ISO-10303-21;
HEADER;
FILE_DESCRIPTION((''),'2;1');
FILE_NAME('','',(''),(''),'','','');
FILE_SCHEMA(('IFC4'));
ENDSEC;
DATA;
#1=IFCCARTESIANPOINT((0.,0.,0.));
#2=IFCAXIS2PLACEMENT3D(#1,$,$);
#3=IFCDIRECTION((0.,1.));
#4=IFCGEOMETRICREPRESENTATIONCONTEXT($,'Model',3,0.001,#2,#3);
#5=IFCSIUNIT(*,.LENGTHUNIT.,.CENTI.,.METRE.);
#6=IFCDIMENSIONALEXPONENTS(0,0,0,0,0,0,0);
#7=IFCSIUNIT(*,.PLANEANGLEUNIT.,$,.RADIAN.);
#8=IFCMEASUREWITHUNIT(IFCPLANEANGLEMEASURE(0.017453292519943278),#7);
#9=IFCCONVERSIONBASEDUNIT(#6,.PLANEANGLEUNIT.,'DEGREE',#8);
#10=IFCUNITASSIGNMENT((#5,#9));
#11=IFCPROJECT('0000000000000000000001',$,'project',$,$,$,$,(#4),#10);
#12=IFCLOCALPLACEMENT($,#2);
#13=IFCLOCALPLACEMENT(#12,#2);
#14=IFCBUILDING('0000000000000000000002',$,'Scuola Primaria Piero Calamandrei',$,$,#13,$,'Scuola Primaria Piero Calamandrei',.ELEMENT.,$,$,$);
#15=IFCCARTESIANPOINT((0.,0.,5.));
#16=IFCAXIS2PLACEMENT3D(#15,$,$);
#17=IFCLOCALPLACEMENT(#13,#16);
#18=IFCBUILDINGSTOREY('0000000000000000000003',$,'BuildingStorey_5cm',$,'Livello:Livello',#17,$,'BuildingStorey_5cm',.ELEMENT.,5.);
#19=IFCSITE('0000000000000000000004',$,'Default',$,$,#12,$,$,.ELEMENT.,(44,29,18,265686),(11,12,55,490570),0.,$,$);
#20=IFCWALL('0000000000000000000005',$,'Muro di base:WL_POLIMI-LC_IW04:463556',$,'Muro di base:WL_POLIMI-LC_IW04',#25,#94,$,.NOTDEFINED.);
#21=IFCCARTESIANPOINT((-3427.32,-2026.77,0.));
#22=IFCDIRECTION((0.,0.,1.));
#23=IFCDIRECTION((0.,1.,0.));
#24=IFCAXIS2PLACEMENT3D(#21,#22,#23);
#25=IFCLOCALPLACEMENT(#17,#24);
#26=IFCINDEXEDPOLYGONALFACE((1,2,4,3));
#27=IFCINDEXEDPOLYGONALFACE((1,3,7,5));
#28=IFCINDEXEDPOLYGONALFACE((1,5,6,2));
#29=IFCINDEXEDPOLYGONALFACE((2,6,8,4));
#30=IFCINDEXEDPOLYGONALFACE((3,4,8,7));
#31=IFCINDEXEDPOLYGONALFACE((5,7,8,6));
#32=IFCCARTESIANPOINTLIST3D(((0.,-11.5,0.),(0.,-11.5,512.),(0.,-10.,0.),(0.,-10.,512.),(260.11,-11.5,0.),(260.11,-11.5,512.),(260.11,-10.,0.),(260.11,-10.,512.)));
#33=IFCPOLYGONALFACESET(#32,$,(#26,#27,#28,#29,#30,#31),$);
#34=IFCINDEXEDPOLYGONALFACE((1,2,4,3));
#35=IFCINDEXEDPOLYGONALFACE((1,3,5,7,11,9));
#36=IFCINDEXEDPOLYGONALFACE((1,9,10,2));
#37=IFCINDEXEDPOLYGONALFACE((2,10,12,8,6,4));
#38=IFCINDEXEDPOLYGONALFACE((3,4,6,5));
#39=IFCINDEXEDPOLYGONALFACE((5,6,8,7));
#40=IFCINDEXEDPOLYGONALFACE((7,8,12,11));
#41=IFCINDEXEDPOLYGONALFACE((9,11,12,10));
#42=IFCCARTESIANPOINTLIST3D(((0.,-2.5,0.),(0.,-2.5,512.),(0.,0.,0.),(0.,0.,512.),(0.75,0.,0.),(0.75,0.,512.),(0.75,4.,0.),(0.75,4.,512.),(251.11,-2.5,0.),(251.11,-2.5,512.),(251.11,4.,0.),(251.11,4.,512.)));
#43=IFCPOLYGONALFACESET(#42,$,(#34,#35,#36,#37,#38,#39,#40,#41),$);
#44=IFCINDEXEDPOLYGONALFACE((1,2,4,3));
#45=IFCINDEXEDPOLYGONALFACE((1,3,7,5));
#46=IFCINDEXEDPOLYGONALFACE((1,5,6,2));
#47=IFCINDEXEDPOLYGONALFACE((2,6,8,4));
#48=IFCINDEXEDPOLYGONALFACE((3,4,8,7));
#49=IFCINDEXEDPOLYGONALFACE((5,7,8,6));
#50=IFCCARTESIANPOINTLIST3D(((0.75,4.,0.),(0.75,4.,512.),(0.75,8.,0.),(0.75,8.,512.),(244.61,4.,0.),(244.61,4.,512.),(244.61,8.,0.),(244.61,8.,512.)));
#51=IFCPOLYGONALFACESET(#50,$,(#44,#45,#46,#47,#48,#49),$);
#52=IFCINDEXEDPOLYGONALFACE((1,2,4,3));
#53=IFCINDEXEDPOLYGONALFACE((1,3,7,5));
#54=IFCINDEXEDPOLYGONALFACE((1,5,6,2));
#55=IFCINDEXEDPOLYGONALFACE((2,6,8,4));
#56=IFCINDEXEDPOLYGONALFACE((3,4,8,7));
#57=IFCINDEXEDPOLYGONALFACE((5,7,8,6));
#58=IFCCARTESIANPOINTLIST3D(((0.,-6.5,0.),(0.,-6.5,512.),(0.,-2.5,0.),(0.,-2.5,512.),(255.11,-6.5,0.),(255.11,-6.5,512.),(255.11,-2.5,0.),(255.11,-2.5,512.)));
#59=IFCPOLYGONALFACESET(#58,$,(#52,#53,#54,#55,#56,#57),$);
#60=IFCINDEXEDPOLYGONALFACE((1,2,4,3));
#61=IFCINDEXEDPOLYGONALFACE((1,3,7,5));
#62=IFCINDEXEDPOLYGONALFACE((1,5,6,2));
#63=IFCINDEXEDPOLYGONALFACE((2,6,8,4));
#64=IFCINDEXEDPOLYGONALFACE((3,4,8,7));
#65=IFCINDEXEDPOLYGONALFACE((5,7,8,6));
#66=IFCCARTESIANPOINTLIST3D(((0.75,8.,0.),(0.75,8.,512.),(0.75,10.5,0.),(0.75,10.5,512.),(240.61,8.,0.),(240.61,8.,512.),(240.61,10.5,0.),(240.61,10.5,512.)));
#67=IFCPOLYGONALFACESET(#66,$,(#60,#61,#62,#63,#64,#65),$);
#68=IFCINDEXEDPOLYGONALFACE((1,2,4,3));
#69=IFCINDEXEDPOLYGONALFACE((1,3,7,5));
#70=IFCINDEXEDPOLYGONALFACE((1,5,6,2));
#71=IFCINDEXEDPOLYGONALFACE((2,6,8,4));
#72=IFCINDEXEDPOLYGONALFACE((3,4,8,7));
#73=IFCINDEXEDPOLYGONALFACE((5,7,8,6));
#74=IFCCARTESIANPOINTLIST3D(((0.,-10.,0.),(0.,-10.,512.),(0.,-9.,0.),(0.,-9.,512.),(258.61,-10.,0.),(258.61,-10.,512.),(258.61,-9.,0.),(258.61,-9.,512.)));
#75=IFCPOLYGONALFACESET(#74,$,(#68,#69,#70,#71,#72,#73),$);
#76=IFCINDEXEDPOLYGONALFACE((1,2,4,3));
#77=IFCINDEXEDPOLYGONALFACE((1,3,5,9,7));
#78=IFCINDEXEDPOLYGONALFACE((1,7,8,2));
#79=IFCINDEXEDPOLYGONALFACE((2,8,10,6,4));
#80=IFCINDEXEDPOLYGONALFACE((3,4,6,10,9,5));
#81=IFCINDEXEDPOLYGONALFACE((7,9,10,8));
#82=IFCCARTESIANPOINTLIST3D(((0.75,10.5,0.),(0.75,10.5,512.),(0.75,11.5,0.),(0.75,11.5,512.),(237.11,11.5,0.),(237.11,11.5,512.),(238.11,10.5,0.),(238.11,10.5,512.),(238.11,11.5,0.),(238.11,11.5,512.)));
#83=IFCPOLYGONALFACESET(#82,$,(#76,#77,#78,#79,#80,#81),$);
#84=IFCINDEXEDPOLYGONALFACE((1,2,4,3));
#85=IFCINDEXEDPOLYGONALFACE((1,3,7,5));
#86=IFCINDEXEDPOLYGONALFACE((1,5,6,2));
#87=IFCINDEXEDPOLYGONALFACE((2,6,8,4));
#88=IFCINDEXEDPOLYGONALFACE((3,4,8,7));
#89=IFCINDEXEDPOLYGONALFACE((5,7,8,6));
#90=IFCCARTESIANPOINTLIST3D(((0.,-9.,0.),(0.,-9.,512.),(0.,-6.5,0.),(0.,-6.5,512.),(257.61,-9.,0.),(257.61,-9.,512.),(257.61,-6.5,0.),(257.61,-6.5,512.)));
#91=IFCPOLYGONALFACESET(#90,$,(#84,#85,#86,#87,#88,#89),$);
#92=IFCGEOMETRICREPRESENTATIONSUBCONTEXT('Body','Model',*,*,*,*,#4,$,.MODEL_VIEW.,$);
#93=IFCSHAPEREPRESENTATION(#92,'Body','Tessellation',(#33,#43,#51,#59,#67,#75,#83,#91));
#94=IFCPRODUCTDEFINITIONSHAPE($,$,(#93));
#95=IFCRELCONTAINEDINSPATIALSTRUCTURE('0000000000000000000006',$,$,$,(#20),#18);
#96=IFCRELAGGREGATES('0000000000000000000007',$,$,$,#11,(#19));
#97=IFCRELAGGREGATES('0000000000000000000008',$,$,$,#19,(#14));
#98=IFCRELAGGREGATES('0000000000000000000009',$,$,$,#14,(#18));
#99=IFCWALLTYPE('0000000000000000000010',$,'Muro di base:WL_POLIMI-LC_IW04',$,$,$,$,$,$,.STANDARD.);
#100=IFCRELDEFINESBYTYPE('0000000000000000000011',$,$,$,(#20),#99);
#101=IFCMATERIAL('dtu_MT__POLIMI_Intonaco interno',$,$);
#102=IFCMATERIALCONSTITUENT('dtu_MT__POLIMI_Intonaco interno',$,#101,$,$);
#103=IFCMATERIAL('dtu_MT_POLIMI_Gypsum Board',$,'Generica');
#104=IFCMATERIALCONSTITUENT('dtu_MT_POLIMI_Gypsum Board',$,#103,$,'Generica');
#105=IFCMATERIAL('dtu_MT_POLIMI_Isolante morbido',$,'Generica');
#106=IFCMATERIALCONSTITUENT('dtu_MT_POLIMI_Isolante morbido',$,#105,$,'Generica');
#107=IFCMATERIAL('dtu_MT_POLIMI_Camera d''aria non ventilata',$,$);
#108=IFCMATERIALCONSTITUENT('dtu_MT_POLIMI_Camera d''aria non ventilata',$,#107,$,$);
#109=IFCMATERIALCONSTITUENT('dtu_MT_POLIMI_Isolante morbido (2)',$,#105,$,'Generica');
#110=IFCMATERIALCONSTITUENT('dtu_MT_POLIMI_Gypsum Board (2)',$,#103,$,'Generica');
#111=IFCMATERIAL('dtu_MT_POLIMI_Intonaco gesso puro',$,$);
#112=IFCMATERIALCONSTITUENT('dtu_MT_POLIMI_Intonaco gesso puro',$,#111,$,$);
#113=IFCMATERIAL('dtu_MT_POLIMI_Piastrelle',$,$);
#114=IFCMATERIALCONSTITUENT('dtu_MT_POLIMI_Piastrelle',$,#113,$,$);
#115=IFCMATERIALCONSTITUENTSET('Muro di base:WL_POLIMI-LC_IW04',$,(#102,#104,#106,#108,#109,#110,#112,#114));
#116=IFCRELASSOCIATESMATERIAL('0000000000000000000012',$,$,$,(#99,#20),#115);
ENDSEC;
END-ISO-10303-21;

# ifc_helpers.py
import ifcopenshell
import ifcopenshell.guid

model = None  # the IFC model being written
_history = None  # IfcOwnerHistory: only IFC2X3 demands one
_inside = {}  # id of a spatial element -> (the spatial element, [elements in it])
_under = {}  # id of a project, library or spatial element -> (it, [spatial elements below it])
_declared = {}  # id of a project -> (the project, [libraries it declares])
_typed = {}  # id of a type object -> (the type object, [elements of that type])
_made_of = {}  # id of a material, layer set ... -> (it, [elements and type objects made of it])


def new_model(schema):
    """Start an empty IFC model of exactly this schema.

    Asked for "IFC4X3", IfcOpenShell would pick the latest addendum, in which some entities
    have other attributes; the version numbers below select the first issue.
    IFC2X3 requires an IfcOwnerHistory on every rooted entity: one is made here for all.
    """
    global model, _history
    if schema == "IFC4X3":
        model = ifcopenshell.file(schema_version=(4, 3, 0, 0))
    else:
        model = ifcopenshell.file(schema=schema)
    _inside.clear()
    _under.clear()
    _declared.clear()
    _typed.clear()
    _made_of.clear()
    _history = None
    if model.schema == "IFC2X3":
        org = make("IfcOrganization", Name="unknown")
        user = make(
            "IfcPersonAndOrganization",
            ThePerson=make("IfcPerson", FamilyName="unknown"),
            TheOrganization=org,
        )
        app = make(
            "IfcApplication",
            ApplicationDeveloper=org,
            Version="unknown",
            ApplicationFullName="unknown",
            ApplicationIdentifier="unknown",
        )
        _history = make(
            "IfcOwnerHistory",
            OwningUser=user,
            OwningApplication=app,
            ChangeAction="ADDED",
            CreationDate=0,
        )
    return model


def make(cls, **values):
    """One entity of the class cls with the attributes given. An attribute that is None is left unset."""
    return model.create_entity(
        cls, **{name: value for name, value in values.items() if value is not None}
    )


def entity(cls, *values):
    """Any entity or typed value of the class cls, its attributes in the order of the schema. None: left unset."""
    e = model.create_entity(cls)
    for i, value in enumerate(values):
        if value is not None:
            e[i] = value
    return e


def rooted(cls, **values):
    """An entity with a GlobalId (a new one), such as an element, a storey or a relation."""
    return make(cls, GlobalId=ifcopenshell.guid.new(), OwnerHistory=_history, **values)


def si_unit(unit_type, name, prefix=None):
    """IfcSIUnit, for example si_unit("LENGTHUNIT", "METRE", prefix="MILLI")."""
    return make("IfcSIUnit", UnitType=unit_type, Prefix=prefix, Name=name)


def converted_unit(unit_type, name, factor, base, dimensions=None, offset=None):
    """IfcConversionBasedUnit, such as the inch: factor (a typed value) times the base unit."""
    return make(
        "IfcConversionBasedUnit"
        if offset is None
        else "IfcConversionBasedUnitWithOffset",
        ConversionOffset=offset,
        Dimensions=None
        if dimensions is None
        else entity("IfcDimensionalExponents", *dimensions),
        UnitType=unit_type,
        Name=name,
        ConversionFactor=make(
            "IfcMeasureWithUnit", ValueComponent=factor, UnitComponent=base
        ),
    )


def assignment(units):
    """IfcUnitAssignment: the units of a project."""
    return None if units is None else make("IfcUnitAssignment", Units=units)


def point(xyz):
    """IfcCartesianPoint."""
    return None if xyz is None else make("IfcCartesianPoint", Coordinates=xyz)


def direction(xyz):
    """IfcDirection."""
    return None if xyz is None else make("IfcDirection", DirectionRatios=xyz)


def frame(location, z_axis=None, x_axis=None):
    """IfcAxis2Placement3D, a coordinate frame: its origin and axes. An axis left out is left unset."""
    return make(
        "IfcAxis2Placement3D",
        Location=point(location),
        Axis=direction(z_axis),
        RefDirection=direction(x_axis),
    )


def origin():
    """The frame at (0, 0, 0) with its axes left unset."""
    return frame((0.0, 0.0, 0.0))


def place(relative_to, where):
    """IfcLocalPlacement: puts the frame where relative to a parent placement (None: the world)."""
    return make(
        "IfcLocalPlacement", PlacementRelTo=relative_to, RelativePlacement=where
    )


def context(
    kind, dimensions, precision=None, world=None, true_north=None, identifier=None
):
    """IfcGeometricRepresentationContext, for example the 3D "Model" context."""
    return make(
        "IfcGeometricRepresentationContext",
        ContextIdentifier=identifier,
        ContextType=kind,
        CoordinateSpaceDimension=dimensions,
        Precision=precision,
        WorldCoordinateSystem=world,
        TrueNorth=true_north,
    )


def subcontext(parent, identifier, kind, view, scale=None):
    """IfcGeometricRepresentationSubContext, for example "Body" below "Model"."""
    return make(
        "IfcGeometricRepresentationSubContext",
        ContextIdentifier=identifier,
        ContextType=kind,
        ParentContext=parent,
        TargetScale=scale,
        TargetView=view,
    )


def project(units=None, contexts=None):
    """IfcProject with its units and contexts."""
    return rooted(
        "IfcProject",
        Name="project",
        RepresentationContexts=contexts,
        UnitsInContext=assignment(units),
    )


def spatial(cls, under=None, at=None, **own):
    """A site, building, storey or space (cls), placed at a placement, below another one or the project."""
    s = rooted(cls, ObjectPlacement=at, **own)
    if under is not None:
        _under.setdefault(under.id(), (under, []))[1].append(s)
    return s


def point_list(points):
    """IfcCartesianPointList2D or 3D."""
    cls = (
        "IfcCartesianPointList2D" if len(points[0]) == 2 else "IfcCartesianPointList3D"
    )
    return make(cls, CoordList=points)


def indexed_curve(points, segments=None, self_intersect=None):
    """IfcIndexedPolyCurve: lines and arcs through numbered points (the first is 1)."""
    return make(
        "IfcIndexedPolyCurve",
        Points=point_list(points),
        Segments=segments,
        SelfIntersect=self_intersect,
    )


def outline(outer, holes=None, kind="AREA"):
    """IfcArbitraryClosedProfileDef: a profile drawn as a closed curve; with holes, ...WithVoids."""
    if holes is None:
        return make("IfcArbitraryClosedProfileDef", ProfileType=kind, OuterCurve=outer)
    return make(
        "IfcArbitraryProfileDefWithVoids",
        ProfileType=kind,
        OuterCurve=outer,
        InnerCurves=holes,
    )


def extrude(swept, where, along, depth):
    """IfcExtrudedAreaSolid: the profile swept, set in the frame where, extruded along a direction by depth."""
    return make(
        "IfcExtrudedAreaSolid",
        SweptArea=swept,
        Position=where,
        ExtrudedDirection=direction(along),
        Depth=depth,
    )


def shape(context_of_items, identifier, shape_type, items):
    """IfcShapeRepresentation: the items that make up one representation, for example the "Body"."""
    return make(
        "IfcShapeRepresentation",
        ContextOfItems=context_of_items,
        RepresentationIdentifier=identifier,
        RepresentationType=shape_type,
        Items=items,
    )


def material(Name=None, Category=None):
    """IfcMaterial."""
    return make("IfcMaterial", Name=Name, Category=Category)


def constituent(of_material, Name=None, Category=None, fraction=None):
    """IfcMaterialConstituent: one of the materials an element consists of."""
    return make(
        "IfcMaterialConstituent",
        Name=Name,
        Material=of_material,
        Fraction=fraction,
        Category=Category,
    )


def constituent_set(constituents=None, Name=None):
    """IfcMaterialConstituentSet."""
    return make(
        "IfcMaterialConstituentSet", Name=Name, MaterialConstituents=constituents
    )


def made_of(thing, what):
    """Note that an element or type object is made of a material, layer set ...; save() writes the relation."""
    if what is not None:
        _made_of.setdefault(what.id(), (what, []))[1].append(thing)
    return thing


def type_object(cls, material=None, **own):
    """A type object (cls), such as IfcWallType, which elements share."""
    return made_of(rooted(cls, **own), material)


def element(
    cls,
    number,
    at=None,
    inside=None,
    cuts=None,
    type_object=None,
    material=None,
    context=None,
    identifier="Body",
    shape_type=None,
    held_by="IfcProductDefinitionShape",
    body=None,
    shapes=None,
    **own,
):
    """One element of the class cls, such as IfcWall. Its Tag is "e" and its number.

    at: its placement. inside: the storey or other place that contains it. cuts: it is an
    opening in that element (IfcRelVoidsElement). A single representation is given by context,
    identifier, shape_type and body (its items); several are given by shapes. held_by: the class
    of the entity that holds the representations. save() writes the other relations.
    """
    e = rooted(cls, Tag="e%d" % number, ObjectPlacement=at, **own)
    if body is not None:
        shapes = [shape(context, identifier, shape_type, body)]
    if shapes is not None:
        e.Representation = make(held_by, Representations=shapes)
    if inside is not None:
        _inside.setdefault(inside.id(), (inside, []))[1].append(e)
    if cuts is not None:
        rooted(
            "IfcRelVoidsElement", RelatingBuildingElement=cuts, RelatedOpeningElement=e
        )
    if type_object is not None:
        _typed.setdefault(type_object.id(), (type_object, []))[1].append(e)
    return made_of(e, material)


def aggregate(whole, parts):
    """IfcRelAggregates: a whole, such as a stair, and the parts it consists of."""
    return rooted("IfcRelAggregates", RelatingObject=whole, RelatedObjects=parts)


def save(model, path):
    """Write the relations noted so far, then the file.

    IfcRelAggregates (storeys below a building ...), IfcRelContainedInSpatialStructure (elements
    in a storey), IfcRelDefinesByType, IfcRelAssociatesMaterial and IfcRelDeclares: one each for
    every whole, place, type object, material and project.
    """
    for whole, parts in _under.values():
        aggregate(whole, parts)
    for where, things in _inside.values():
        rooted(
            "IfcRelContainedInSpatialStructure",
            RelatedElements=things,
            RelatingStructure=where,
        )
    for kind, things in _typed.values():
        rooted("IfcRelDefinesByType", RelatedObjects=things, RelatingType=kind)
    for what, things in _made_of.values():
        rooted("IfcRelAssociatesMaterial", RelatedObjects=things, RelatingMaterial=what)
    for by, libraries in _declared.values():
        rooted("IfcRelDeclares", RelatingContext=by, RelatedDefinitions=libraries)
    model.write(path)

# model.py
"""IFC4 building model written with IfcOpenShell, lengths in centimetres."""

from ifc_helpers import new_model, entity, si_unit, converted_unit, direction, frame, origin, place, context, subcontext, project, spatial, indexed_curve, outline, extrude, material, constituent, constituent_set, type_object, element, save


model = new_model("IFC4")

# Units and contexts
model_context = context("Model", 3, precision=0.001, world=origin(), true_north=direction((0.0, 1.0)))
body_context = subcontext(model_context, "Body", "Model", "MODEL_VIEW")
ifc_project = project(units=[si_unit("LENGTHUNIT", "METRE", prefix="CENTI"), converted_unit("PLANEANGLEUNIT", "DEGREE", entity("IfcPlaneAngleMeasure", 0.017453292519943278), si_unit("PLANEANGLEUNIT", "RADIAN"), dimensions=[0, 0, 0, 0, 0, 0, 0])], contexts=[model_context])

# Site, building, storey
site_placement = place(None, origin())
site = spatial("IfcSite", under=ifc_project, at=site_placement, Name="Default", CompositionType="ELEMENT", RefLatitude=(44, 29, 18, 265686), RefLongitude=(11, 12, 55, 490570), RefElevation=0.0)
building_placement = place(site_placement, origin())
building = spatial("IfcBuilding", under=site, at=building_placement, Name="Scuola Primaria Piero Calamandrei", LongName="Scuola Primaria Piero Calamandrei", CompositionType="ELEMENT")
storey_placement = place(building_placement, frame((0.0, 0.0, 5.0)))
storey = spatial("IfcBuildingStorey", under=building, at=storey_placement, Name="BuildingStorey_5cm", ObjectType="Livello:Livello", LongName="BuildingStorey_5cm", CompositionType="ELEMENT", Elevation=5.0)

# Shared definitions
ifc_material_1 = material(Name="dtu_MT_POLIMI_Intonaco gesso puro")

# Shared definitions
ifc_material_2 = material(Name="dtu_MT__POLIMI_Intonaco interno")

# Shared definitions
ifc_material_3 = material(Name="dtu_MT_POLIMI_Gypsum Board", Category="Generica")
ifc_material_4 = material(Name="dtu_MT_POLIMI_Isolante morbido", Category="Generica")
ifc_material_5 = material(Name="dtu_MT_POLIMI_Camera d'aria non ventilata")

# Wall
ifc_constituent_1 = constituent(ifc_material_2, Name="dtu_MT__POLIMI_Intonaco interno")
ifc_constituent_2 = constituent(ifc_material_3, Name="dtu_MT_POLIMI_Gypsum Board", Category="Generica")
ifc_constituent_3 = constituent(ifc_material_4, Name="dtu_MT_POLIMI_Isolante morbido", Category="Generica")
ifc_constituent_4 = constituent(ifc_material_5, Name="dtu_MT_POLIMI_Camera d'aria non ventilata")
ifc_constituent_5 = constituent(ifc_material_4, Name="dtu_MT_POLIMI_Isolante morbido (2)", Category="Generica")
ifc_constituent_6 = constituent(ifc_material_3, Name="dtu_MT_POLIMI_Gypsum Board (2)", Category="Generica")
ifc_constituent_7 = constituent(ifc_material_1, Name="dtu_MT_POLIMI_Intonaco gesso puro")
ifc_material_6 = material(Name="dtu_MT_POLIMI_Piastrelle")
ifc_constituent_8 = constituent(ifc_material_6, Name="dtu_MT_POLIMI_Piastrelle")
ifc_constituent_set_1 = constituent_set(constituents=[ifc_constituent_1, ifc_constituent_2, ifc_constituent_3, ifc_constituent_4, ifc_constituent_5, ifc_constituent_6, ifc_constituent_7, ifc_constituent_8], Name="Muro di base:WL_POLIMI-LC_IW04")
wall_type_1 = type_object("IfcWallType", Name="Muro di base:WL_POLIMI-LC_IW04", PredefinedType="STANDARD", material=ifc_constituent_set_1)
wall_1_placement = place(storey_placement, frame((-3427.32, -2026.77, 0.0), z_axis=(0.0, 0.0, 1.0), x_axis=(0.0, 1.0, 0.0)))
element("IfcWall", 1, at=wall_1_placement, inside=storey, type_object=wall_type_1, material=ifc_constituent_set_1, Name="Muro di base:WL_POLIMI-LC_IW04:463556", ObjectType="Muro di base:WL_POLIMI-LC_IW04", PredefinedType="NOTDEFINED", context=body_context, shape_type="SweptSolid", body=[
    extrude(outline(indexed_curve([(-0.75, -130.06), (0.75, -130.06), (0.75, 130.06), (-0.75, 130.06), (-0.75, -130.06)], self_intersect=False)), frame((130.06, -10.75, 0.0), z_axis=(0.0, 0.0, 1.0), x_axis=(0.0, 1.0, 0.0)), (0.0, 0.0, 1.0), 512.0),
    extrude(outline(indexed_curve([(0.5, -83.95), (3.0, -83.95), (3.0, 167.16), (-3.5, 167.16), (-3.5, -83.2), (0.5, -83.2), (0.5, -83.95)], self_intersect=False)), frame((83.95, 0.5, 0.0), z_axis=(0.0, 0.0, 1.0), x_axis=(0.0, -1.0, 0.0)), (0.0, 0.0, 1.0), 512.0),
    extrude(outline(indexed_curve([(-121.93, -2.0), (121.93, -2.0), (121.93, 2.0), (-121.93, 2.0), (-121.93, -2.0)], self_intersect=False)), frame((122.68, 6.0, 0.0)), (0.0, 0.0, 1.0), 512.0),
    extrude(outline(indexed_curve([(-127.56, -2.0), (127.56, -2.0), (127.56, 2.0), (-127.56, 2.0), (-127.56, -2.0)], self_intersect=False)), frame((127.56, -4.5, 0.0)), (0.0, 0.0, 1.0), 512.0),
    extrude(outline(indexed_curve([(-119.93, -1.25), (119.93, -1.25), (119.93, 1.25), (-119.93, 1.25), (-119.93, -1.25)], self_intersect=False)), frame((120.68, 9.25, 0.0)), (0.0, 0.0, 1.0), 512.0),
    extrude(outline(indexed_curve([(-129.31, -0.5), (129.31, -0.5), (129.31, 0.5), (-129.31, 0.5), (-129.31, -0.5)], self_intersect=False)), frame((129.31, -9.5, 0.0)), (0.0, 0.0, 1.0), 512.0),
    extrude(outline(indexed_curve([(-94.15, -0.4), (142.22, -0.4), (142.22, 0.6), (-95.15, 0.6), (-95.15, -0.4), (-94.15, -0.4)], self_intersect=False)), frame((142.97, 11.1, 0.0), z_axis=(0.0, 0.0, 1.0), x_axis=(-1.0, 0.0, 0.0)), (0.0, 0.0, 1.0), 512.0),
    extrude(outline(indexed_curve([(-128.81, -1.25), (128.81, -1.25), (128.81, 1.25), (-128.81, 1.25), (-128.81, -1.25)], self_intersect=False)), frame((128.81, -7.75, 0.0)), (0.0, 0.0, 1.0), 512.0),
])

save(model, "model.ifc")
